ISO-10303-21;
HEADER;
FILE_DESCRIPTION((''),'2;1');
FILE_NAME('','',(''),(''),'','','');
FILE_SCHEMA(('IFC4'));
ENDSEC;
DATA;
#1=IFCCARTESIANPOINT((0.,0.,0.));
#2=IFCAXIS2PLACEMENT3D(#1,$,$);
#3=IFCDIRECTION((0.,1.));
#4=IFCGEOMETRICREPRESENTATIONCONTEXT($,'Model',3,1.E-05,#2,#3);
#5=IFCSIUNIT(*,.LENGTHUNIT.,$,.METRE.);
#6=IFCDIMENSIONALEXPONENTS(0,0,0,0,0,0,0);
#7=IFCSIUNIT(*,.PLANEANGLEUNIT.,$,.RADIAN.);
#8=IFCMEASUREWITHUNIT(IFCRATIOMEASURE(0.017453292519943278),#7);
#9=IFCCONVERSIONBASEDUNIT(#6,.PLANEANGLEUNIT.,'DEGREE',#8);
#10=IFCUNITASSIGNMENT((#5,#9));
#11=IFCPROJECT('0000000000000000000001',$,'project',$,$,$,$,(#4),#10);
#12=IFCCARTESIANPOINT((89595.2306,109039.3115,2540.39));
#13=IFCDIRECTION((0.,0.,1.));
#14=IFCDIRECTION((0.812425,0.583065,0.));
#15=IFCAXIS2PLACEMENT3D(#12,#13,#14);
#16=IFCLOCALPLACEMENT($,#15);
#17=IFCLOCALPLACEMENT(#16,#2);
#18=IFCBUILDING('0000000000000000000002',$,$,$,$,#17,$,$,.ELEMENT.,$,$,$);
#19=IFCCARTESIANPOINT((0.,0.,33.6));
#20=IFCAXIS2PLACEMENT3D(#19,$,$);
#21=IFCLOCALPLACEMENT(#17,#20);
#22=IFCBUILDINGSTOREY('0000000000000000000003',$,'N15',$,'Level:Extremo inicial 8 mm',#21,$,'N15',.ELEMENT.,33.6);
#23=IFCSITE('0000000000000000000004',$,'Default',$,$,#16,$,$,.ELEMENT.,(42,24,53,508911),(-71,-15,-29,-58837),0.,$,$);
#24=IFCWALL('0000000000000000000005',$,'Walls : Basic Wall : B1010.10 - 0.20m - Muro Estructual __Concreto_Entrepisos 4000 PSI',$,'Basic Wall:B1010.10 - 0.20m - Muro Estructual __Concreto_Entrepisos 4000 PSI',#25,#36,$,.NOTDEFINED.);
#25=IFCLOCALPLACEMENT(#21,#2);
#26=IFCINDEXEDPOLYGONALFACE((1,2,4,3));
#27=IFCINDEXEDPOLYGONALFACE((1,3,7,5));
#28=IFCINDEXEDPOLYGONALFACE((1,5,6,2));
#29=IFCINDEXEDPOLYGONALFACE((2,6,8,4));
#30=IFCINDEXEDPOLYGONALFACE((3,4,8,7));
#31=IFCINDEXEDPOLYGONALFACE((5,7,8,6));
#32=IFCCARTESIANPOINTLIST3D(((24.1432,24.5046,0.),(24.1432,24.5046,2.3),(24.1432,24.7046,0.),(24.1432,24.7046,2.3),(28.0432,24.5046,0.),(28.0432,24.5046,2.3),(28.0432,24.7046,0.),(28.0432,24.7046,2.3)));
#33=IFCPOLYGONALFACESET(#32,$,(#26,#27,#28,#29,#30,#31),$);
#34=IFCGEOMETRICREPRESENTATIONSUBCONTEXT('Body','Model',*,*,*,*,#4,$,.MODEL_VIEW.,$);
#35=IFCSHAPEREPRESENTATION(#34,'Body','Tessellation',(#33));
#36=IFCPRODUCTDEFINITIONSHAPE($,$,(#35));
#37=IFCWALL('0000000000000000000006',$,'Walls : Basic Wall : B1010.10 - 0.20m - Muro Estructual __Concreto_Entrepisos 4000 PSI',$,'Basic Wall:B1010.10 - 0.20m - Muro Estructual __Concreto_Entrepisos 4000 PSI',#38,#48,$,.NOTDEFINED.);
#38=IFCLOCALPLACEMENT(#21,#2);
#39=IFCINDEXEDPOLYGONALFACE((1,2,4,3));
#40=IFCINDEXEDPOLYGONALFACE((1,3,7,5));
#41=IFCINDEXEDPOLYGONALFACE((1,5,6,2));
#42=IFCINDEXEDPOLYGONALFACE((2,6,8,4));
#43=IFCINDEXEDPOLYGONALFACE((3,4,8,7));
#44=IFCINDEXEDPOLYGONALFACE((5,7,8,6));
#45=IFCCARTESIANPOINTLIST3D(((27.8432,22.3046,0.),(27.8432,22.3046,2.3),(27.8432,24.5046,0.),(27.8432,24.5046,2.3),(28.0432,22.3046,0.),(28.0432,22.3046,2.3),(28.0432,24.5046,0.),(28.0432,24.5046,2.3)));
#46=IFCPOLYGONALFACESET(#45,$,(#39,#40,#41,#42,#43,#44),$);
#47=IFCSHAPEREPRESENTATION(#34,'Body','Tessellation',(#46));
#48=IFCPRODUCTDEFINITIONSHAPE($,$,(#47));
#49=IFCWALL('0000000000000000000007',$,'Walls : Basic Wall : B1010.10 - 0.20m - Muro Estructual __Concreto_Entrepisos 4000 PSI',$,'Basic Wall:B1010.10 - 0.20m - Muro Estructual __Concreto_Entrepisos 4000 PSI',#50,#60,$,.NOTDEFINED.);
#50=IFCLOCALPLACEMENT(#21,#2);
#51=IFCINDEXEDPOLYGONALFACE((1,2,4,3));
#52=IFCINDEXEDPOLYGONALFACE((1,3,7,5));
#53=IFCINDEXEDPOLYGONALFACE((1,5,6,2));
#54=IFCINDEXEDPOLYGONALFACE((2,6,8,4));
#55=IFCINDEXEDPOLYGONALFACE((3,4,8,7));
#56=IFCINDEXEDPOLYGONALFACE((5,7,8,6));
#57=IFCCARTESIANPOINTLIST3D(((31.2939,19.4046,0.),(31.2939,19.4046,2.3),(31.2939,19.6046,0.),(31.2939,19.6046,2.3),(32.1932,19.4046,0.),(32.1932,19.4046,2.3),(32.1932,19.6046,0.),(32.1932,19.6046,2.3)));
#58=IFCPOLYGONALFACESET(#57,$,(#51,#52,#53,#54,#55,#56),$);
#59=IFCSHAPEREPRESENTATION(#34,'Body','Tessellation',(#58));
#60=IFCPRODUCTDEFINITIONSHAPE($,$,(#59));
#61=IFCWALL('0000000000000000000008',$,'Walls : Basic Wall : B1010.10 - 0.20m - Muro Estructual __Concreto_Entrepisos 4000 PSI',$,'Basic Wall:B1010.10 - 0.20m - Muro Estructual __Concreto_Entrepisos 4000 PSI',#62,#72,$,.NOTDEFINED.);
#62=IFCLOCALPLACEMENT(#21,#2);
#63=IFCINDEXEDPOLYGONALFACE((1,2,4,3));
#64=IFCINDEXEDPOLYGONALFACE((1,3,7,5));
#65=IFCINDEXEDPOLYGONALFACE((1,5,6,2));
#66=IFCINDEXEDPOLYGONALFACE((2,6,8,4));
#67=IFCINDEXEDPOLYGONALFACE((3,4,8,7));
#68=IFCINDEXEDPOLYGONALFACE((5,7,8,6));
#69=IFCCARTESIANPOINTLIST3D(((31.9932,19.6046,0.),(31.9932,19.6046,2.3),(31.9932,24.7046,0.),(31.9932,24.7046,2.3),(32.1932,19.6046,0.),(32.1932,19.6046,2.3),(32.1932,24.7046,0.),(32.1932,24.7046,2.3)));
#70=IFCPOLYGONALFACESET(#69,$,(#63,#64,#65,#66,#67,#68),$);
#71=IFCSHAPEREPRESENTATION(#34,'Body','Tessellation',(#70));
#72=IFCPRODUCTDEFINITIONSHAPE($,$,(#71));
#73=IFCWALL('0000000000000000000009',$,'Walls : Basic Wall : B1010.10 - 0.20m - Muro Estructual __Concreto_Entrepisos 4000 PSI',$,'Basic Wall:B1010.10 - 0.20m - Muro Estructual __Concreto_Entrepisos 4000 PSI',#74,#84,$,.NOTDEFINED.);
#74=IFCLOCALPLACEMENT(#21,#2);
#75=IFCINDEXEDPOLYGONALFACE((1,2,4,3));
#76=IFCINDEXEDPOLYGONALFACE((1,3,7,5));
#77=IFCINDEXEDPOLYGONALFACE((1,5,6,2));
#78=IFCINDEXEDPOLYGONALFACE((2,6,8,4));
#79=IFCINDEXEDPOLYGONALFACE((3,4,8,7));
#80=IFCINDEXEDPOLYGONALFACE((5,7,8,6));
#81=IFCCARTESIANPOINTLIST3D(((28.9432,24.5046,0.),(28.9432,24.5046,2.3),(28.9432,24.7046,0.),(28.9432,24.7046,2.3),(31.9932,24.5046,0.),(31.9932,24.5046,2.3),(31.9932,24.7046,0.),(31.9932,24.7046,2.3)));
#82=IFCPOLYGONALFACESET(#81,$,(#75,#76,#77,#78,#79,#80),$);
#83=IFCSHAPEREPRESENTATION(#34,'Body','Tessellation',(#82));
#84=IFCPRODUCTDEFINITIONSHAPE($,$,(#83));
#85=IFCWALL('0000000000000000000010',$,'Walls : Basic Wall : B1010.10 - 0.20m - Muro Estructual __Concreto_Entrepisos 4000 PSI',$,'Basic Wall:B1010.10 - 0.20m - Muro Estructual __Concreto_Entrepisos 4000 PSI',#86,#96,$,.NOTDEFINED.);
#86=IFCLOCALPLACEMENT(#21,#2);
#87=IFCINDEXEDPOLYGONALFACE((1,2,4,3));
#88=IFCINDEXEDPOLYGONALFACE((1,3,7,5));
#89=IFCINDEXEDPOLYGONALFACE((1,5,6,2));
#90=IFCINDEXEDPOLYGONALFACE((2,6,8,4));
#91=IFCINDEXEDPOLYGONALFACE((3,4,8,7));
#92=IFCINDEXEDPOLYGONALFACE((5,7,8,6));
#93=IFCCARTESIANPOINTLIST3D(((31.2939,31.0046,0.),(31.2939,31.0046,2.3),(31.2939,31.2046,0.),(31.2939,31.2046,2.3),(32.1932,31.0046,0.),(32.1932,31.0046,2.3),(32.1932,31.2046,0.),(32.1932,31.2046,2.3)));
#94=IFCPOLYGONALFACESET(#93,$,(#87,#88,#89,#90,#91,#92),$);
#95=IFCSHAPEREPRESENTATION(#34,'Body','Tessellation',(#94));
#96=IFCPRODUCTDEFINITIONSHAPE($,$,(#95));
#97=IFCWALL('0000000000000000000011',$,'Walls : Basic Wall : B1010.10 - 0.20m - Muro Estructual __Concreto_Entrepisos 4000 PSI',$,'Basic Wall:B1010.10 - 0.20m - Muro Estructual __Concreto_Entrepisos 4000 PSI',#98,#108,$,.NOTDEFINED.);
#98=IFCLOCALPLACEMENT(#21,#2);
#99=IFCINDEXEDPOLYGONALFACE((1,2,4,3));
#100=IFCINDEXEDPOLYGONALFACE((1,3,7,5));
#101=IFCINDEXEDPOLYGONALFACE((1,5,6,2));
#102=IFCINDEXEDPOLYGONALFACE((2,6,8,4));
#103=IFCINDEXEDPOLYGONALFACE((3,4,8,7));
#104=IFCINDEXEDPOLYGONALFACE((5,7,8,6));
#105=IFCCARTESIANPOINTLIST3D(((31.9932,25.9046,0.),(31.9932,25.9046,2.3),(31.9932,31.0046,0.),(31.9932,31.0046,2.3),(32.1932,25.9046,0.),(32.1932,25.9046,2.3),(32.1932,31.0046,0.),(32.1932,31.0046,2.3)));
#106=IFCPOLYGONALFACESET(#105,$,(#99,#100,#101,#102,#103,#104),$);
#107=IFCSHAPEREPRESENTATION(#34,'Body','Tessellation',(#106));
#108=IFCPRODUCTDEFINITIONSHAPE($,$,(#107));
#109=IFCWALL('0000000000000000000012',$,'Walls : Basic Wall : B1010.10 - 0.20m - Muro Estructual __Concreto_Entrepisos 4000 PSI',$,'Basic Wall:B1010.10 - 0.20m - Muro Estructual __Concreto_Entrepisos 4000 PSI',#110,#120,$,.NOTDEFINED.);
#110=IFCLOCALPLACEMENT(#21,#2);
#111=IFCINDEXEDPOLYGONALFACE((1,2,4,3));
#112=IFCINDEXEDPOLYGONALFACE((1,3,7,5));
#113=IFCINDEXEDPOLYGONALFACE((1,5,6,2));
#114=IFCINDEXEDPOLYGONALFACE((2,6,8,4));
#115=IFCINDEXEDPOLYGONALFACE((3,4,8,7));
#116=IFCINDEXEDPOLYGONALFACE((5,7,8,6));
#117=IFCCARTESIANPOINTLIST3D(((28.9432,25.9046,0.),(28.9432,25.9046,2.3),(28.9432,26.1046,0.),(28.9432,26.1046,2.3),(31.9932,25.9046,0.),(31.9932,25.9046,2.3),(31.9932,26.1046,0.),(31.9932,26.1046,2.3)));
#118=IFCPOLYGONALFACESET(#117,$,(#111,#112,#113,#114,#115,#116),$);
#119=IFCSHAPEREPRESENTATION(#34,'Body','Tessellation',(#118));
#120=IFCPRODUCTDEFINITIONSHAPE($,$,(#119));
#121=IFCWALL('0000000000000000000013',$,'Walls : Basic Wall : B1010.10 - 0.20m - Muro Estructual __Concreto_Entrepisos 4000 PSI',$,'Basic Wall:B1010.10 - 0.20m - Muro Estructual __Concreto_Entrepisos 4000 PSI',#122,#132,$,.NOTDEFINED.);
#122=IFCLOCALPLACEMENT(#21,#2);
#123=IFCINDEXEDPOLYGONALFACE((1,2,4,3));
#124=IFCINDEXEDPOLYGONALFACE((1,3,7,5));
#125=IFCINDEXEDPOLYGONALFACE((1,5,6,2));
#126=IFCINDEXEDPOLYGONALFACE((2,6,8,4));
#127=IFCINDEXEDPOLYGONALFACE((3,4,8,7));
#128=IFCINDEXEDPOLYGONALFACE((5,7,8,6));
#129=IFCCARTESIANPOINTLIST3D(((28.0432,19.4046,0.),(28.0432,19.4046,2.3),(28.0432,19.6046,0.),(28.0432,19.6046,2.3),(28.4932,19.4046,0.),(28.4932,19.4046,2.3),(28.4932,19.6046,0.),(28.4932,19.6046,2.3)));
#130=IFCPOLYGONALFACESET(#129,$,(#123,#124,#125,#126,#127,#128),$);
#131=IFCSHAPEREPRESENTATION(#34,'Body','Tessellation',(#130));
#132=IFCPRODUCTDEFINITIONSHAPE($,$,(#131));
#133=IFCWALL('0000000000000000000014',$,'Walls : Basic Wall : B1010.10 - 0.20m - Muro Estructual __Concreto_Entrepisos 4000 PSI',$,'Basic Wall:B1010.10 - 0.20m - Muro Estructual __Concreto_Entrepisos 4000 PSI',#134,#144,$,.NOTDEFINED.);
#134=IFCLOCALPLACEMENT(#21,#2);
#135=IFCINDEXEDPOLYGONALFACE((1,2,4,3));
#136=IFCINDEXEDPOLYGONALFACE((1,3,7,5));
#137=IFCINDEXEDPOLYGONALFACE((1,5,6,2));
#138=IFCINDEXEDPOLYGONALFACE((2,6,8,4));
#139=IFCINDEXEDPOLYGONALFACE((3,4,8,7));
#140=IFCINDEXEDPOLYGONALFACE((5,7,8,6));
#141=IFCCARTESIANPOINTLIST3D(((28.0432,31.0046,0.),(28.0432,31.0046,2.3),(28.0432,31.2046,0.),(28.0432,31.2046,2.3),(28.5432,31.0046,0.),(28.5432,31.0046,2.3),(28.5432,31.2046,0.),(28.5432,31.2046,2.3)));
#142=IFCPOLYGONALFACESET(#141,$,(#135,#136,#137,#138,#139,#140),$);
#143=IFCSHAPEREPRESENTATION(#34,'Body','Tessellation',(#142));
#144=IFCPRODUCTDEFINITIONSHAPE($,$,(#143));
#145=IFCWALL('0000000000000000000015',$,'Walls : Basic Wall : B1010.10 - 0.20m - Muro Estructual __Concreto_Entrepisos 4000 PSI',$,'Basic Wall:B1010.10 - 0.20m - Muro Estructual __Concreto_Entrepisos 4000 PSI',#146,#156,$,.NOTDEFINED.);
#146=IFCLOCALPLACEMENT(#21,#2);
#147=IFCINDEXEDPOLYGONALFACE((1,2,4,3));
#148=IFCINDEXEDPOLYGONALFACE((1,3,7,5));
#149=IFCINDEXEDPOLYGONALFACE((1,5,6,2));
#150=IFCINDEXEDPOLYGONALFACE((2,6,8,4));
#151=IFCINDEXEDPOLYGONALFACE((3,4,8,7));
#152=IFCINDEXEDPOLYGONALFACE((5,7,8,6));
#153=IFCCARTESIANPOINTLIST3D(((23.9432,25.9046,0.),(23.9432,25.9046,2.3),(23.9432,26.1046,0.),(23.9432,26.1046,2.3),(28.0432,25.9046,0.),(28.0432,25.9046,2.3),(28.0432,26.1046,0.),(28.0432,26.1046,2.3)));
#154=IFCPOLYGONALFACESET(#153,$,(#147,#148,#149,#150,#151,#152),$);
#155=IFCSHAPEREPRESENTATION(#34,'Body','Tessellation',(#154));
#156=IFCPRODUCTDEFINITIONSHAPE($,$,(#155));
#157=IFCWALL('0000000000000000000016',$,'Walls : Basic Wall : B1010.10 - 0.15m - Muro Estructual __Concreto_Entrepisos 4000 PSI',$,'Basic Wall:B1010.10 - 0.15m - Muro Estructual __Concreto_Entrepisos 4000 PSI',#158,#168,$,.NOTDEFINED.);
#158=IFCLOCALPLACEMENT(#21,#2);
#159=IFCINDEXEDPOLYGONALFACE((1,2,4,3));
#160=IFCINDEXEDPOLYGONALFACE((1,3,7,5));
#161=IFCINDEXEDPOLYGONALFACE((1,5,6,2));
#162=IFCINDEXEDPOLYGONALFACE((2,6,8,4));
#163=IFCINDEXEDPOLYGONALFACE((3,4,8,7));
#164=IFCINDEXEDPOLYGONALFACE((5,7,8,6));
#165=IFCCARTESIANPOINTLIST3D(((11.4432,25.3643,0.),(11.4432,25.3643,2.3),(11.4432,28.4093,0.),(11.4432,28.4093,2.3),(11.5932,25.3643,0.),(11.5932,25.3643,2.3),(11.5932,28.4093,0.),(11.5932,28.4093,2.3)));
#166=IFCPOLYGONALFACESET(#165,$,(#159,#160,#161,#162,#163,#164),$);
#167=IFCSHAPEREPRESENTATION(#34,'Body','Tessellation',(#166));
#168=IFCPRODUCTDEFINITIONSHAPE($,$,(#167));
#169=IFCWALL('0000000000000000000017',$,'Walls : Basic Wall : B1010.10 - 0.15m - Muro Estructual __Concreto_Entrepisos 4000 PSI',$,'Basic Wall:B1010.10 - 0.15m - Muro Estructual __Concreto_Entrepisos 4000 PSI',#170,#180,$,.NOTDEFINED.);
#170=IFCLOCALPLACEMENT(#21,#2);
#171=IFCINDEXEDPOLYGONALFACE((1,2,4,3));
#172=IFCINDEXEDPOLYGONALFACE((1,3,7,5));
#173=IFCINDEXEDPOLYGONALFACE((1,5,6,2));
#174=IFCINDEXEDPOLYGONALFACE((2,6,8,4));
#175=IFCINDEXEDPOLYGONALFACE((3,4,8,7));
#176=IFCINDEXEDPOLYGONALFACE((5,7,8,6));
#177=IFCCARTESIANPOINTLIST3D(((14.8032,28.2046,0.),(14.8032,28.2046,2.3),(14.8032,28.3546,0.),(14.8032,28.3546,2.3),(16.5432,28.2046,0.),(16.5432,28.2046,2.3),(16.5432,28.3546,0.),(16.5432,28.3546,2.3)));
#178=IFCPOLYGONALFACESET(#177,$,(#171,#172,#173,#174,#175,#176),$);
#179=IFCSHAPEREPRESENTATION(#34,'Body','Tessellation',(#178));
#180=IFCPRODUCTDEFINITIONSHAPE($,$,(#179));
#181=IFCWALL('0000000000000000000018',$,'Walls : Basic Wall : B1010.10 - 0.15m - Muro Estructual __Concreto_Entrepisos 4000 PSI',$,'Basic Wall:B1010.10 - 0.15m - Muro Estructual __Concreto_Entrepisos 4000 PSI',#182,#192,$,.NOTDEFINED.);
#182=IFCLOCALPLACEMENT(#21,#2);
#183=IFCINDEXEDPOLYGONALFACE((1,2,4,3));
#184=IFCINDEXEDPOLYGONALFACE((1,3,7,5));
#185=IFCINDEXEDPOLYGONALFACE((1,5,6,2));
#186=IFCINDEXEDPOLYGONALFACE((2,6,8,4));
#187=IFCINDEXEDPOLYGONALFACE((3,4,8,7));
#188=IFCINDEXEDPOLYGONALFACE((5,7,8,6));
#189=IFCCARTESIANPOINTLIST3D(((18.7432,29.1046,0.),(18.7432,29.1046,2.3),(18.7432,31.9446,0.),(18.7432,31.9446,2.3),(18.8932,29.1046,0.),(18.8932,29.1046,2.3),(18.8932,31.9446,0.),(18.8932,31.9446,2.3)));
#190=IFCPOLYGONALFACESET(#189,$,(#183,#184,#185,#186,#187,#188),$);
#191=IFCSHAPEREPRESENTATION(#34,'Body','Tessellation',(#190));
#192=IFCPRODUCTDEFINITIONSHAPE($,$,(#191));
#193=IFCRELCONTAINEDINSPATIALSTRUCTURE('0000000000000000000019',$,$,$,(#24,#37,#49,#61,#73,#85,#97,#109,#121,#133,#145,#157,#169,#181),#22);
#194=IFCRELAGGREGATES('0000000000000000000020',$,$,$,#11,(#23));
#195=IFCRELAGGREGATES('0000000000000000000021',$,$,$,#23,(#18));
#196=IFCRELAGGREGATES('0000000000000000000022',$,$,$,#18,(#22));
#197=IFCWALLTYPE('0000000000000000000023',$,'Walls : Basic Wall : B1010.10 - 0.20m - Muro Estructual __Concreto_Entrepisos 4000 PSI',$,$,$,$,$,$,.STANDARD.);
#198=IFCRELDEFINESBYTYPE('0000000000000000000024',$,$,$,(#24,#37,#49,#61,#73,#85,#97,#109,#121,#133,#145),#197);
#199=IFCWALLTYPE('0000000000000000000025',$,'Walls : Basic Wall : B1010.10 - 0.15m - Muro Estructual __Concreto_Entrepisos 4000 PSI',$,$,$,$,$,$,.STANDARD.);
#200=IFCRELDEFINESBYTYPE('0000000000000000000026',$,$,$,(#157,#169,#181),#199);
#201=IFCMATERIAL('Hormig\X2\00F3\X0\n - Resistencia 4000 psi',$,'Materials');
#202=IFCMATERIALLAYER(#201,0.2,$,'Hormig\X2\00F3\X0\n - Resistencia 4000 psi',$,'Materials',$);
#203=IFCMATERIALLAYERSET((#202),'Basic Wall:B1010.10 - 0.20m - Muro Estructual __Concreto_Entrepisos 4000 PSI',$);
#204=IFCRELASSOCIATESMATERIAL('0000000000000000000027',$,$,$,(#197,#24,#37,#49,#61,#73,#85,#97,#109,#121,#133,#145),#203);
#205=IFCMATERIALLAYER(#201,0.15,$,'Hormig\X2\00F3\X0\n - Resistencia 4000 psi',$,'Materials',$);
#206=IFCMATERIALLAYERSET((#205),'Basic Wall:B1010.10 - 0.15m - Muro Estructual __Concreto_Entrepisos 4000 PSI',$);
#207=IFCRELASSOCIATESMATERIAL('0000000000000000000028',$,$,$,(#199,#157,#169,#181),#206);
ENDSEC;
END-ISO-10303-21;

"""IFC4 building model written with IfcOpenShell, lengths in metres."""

from ifc_helpers import new_model, entity, si_unit, converted_unit, direction, frame, frame_2d, origin, place, context, subcontext, project, spatial, rectangle, extrude, material, layer, layer_set, layer_usage, type_object, element, save


model = new_model("IFC4")

# Units and contexts
model_context = context("Model", 3, precision=1e-05, world=origin(), true_north=direction((0.0, 1.0)))
body_context = subcontext(model_context, "Body", "Model", "MODEL_VIEW")
ifc_project = project(units=[si_unit("LENGTHUNIT", "METRE"), converted_unit("PLANEANGLEUNIT", "DEGREE", entity("IfcRatioMeasure", 0.017453292519943278), si_unit("PLANEANGLEUNIT", "RADIAN"), dimensions=[0, 0, 0, 0, 0, 0, 0])], contexts=[model_context])

# Site, building, storey
site_placement = place(None, frame((89595.2306, 109039.3115, 2540.39), z_axis=(0.0, 0.0, 1.0), x_axis=(0.812425, 0.583065, 0.0)))
site = spatial("IfcSite", under=ifc_project, at=site_placement, Name="Default", CompositionType="ELEMENT", RefLatitude=(42, 24, 53, 508911), RefLongitude=(-71, -15, -29, -58837), RefElevation=0.0)
building_placement = place(site_placement, origin())
building = spatial("IfcBuilding", under=site, at=building_placement, CompositionType="ELEMENT")
storey_placement = place(building_placement, frame((0.0, 0.0, 33.6)))
storey = spatial("IfcBuildingStorey", under=building, at=storey_placement, Name="N15", ObjectType="Level:Extremo inicial 8 mm", LongName="N15", CompositionType="ELEMENT", Elevation=33.6)

# Walls
ifc_material_1 = material(Name="Hormigón - Resistencia 4000 psi", Category="Materials")
ifc_layer_1 = layer(ifc_material_1, 0.2, Name="Hormigón - Resistencia 4000 psi", Category="Materials")
ifc_layer_set_1 = layer_set([ifc_layer_1], Name="Basic Wall:B1010.10 - 0.20m - Muro Estructual __Concreto_Entrepisos 4000 PSI")
wall_type_1 = type_object("IfcWallType", Name="Walls : Basic Wall : B1010.10 - 0.20m - Muro Estructual __Concreto_Entrepisos 4000 PSI", PredefinedType="STANDARD", material=ifc_layer_set_1)
ifc_layer_usage_1 = layer_usage(ifc_layer_set_1, "AXIS2", "NEGATIVE", 0.1)
wall_1_placement = place(storey_placement, frame((24.1432, 24.6046, 0.0)))
element("IfcWall", 1, at=wall_1_placement, inside=storey, type_object=wall_type_1, material=ifc_layer_usage_1, Name="Walls : Basic Wall : B1010.10 - 0.20m - Muro Estructual __Concreto_Entrepisos 4000 PSI", ObjectType="Basic Wall:B1010.10 - 0.20m - Muro Estructual __Concreto_Entrepisos 4000 PSI", PredefinedType="NOTDEFINED", context=body_context, shape_type="SweptSolid", body=[
    extrude(rectangle(XDim=3.9, YDim=0.2, at=frame_2d((1.95, 0.0), x_axis=(-1.0, 0.0))), origin(), (0.0, 0.0, 1.0), 2.3),
])
ifc_layer_usage_2 = layer_usage(ifc_layer_set_1, "AXIS2", "NEGATIVE", 0.1)
wall_2_placement = place(storey_placement, frame((27.9432, 24.5046, 0.0), z_axis=(0.0, 0.0, 1.0), x_axis=(0.0, -1.0, 0.0)))
element("IfcWall", 2, at=wall_2_placement, inside=storey, type_object=wall_type_1, material=ifc_layer_usage_2, Name="Walls : Basic Wall : B1010.10 - 0.20m - Muro Estructual __Concreto_Entrepisos 4000 PSI", ObjectType="Basic Wall:B1010.10 - 0.20m - Muro Estructual __Concreto_Entrepisos 4000 PSI", PredefinedType="NOTDEFINED", context=body_context, shape_type="SweptSolid", body=[
    extrude(rectangle(XDim=2.2, YDim=0.2, at=frame_2d((1.1, 0.0), x_axis=(-1.0, 0.0))), origin(), (0.0, 0.0, 1.0), 2.3),
])
ifc_layer_usage_3 = layer_usage(ifc_layer_set_1, "AXIS2", "NEGATIVE", 0.1)
wall_3_placement = place(storey_placement, frame((31.2939, 19.5046, 0.0)))
element("IfcWall", 3, at=wall_3_placement, inside=storey, type_object=wall_type_1, material=ifc_layer_usage_3, Name="Walls : Basic Wall : B1010.10 - 0.20m - Muro Estructual __Concreto_Entrepisos 4000 PSI", ObjectType="Basic Wall:B1010.10 - 0.20m - Muro Estructual __Concreto_Entrepisos 4000 PSI", PredefinedType="NOTDEFINED", context=body_context, shape_type="SweptSolid", body=[
    extrude(rectangle(XDim=0.8993, YDim=0.2, at=frame_2d((0.4497, 0.0), x_axis=(-1.0, 0.0))), origin(), (0.0, 0.0, 1.0), 2.3),
])
ifc_layer_usage_4 = layer_usage(ifc_layer_set_1, "AXIS2", "NEGATIVE", 0.1)
wall_4_placement = place(storey_placement, frame((32.0932, 19.6046, 0.0), z_axis=(0.0, 0.0, 1.0), x_axis=(0.0, 1.0, 0.0)))
element("IfcWall", 4, at=wall_4_placement, inside=storey, type_object=wall_type_1, material=ifc_layer_usage_4, Name="Walls : Basic Wall : B1010.10 - 0.20m - Muro Estructual __Concreto_Entrepisos 4000 PSI", ObjectType="Basic Wall:B1010.10 - 0.20m - Muro Estructual __Concreto_Entrepisos 4000 PSI", PredefinedType="NOTDEFINED", context=body_context, shape_type="SweptSolid", body=[
    extrude(rectangle(XDim=5.1, YDim=0.2, at=frame_2d((2.55, 0.0), x_axis=(-1.0, 0.0))), origin(), (0.0, 0.0, 1.0), 2.3),
])
ifc_layer_usage_5 = layer_usage(ifc_layer_set_1, "AXIS2", "NEGATIVE", 0.1)
wall_5_placement = place(storey_placement, frame((31.9932, 24.6046, 0.0), z_axis=(0.0, 0.0, 1.0), x_axis=(-1.0, 0.0, 0.0)))
element("IfcWall", 5, at=wall_5_placement, inside=storey, type_object=wall_type_1, material=ifc_layer_usage_5, Name="Walls : Basic Wall : B1010.10 - 0.20m - Muro Estructual __Concreto_Entrepisos 4000 PSI", ObjectType="Basic Wall:B1010.10 - 0.20m - Muro Estructual __Concreto_Entrepisos 4000 PSI", PredefinedType="NOTDEFINED", context=body_context, shape_type="SweptSolid", body=[
    extrude(rectangle(XDim=3.05, YDim=0.2, at=frame_2d((1.525, 0.0), x_axis=(-1.0, 0.0))), origin(), (0.0, 0.0, 1.0), 2.3),
])
ifc_layer_usage_6 = layer_usage(ifc_layer_set_1, "AXIS2", "POSITIVE", -0.1)
wall_6_placement = place(storey_placement, frame((31.2939, 31.1046, 0.0)))
element("IfcWall", 6, at=wall_6_placement, inside=storey, type_object=wall_type_1, material=ifc_layer_usage_6, Name="Walls : Basic Wall : B1010.10 - 0.20m - Muro Estructual __Concreto_Entrepisos 4000 PSI", ObjectType="Basic Wall:B1010.10 - 0.20m - Muro Estructual __Concreto_Entrepisos 4000 PSI", PredefinedType="NOTDEFINED", context=body_context, shape_type="SweptSolid", body=[
    extrude(rectangle(XDim=0.8993, YDim=0.2, at=frame_2d((0.4497, 0.0), x_axis=(-1.0, 0.0))), origin(), (0.0, 0.0, 1.0), 2.3),
])
ifc_layer_usage_7 = layer_usage(ifc_layer_set_1, "AXIS2", "POSITIVE", -0.1)
wall_7_placement = place(storey_placement, frame((32.0932, 31.0046, 0.0), z_axis=(0.0, 0.0, 1.0), x_axis=(0.0, -1.0, 0.0)))
element("IfcWall", 7, at=wall_7_placement, inside=storey, type_object=wall_type_1, material=ifc_layer_usage_7, Name="Walls : Basic Wall : B1010.10 - 0.20m - Muro Estructual __Concreto_Entrepisos 4000 PSI", ObjectType="Basic Wall:B1010.10 - 0.20m - Muro Estructual __Concreto_Entrepisos 4000 PSI", PredefinedType="NOTDEFINED", context=body_context, shape_type="SweptSolid", body=[
    extrude(rectangle(XDim=5.1, YDim=0.2, at=frame_2d((2.55, 0.0), x_axis=(-1.0, 0.0))), origin(), (0.0, 0.0, 1.0), 2.3),
])
ifc_layer_usage_8 = layer_usage(ifc_layer_set_1, "AXIS2", "POSITIVE", -0.1)
wall_8_placement = place(storey_placement, frame((31.9932, 26.0046, 0.0), z_axis=(0.0, 0.0, 1.0), x_axis=(-1.0, 0.0, 0.0)))
element("IfcWall", 8, at=wall_8_placement, inside=storey, type_object=wall_type_1, material=ifc_layer_usage_8, Name="Walls : Basic Wall : B1010.10 - 0.20m - Muro Estructual __Concreto_Entrepisos 4000 PSI", ObjectType="Basic Wall:B1010.10 - 0.20m - Muro Estructual __Concreto_Entrepisos 4000 PSI", PredefinedType="NOTDEFINED", context=body_context, shape_type="SweptSolid", body=[
    extrude(rectangle(XDim=3.05, YDim=0.2, at=frame_2d((1.525, 0.0), x_axis=(-1.0, 0.0))), origin(), (0.0, 0.0, 1.0), 2.3),
])
ifc_layer_usage_9 = layer_usage(ifc_layer_set_1, "AXIS2", "NEGATIVE", 0.1)
wall_9_placement = place(storey_placement, frame((28.4932, 19.5046, 0.0), z_axis=(0.0, 0.0, 1.0), x_axis=(-1.0, 0.0, 0.0)))
element("IfcWall", 9, at=wall_9_placement, inside=storey, type_object=wall_type_1, material=ifc_layer_usage_9, Name="Walls : Basic Wall : B1010.10 - 0.20m - Muro Estructual __Concreto_Entrepisos 4000 PSI", ObjectType="Basic Wall:B1010.10 - 0.20m - Muro Estructual __Concreto_Entrepisos 4000 PSI", PredefinedType="NOTDEFINED", context=body_context, shape_type="SweptSolid", body=[
    extrude(rectangle(XDim=0.45, YDim=0.2, at=frame_2d((0.225, 0.0), x_axis=(-1.0, 0.0))), origin(), (0.0, 0.0, 1.0), 2.3),
])
ifc_layer_usage_10 = layer_usage(ifc_layer_set_1, "AXIS2", "NEGATIVE", 0.1)
wall_10_placement = place(storey_placement, frame((28.5432, 31.1046, 0.0), z_axis=(0.0, 0.0, 1.0), x_axis=(-1.0, 0.0, 0.0)))
element("IfcWall", 10, at=wall_10_placement, inside=storey, type_object=wall_type_1, material=ifc_layer_usage_10, Name="Walls : Basic Wall : B1010.10 - 0.20m - Muro Estructual __Concreto_Entrepisos 4000 PSI", ObjectType="Basic Wall:B1010.10 - 0.20m - Muro Estructual __Concreto_Entrepisos 4000 PSI", PredefinedType="NOTDEFINED", context=body_context, shape_type="SweptSolid", body=[
    extrude(rectangle(XDim=0.5, YDim=0.2, at=frame_2d((0.25, 0.0), x_axis=(-1.0, 0.0))), origin(), (0.0, 0.0, 1.0), 2.3),
])
ifc_layer_usage_11 = layer_usage(ifc_layer_set_1, "AXIS2", "NEGATIVE", 0.1)
wall_11_placement = place(storey_placement, frame((23.9432, 26.0046, 0.0)))
element("IfcWall", 11, at=wall_11_placement, inside=storey, type_object=wall_type_1, material=ifc_layer_usage_11, Name="Walls : Basic Wall : B1010.10 - 0.20m - Muro Estructual __Concreto_Entrepisos 4000 PSI", ObjectType="Basic Wall:B1010.10 - 0.20m - Muro Estructual __Concreto_Entrepisos 4000 PSI", PredefinedType="NOTDEFINED", context=body_context, shape_type="SweptSolid", body=[
    extrude(rectangle(XDim=4.1, YDim=0.2, at=frame_2d((2.05, 0.0), x_axis=(-1.0, 0.0))), origin(), (0.0, 0.0, 1.0), 2.3),
])
ifc_layer_2 = layer(ifc_material_1, 0.15, Name="Hormigón - Resistencia 4000 psi", Category="Materials")
ifc_layer_set_2 = layer_set([ifc_layer_2], Name="Basic Wall:B1010.10 - 0.15m - Muro Estructual __Concreto_Entrepisos 4000 PSI")
ifc_layer_usage_12 = layer_usage(ifc_layer_set_2, "AXIS2", "NEGATIVE", 0.075)
wall_type_2 = type_object("IfcWallType", Name="Walls : Basic Wall : B1010.10 - 0.15m - Muro Estructual __Concreto_Entrepisos 4000 PSI", PredefinedType="STANDARD", material=ifc_layer_set_2)
wall_12_placement = place(storey_placement, frame((11.5182, 25.3643, 0.0), z_axis=(0.0, 0.0, 1.0), x_axis=(0.0, 1.0, 0.0)))
element("IfcWall", 12, at=wall_12_placement, inside=storey, type_object=wall_type_2, material=ifc_layer_usage_12, Name="Walls : Basic Wall : B1010.10 - 0.15m - Muro Estructual __Concreto_Entrepisos 4000 PSI", ObjectType="Basic Wall:B1010.10 - 0.15m - Muro Estructual __Concreto_Entrepisos 4000 PSI", PredefinedType="NOTDEFINED", context=body_context, shape_type="SweptSolid", body=[
    extrude(rectangle(XDim=3.045, YDim=0.15, at=frame_2d((1.5225, 0.0), x_axis=(-1.0, 0.0))), origin(), (0.0, 0.0, 1.0), 2.3),
])
ifc_layer_usage_13 = layer_usage(ifc_layer_set_2, "AXIS2", "NEGATIVE", 0.075)
wall_13_placement = place(storey_placement, frame((16.5432, 28.2796, 0.0), z_axis=(0.0, 0.0, 1.0), x_axis=(-1.0, 0.0, 0.0)))
element("IfcWall", 13, at=wall_13_placement, inside=storey, type_object=wall_type_2, material=ifc_layer_usage_13, Name="Walls : Basic Wall : B1010.10 - 0.15m - Muro Estructual __Concreto_Entrepisos 4000 PSI", ObjectType="Basic Wall:B1010.10 - 0.15m - Muro Estructual __Concreto_Entrepisos 4000 PSI", PredefinedType="NOTDEFINED", context=body_context, shape_type="SweptSolid", body=[
    extrude(rectangle(XDim=1.74, YDim=0.15, at=frame_2d((0.87, 0.0), x_axis=(-1.0, 0.0))), origin(), (0.0, 0.0, 1.0), 2.3),
])
ifc_layer_usage_14 = layer_usage(ifc_layer_set_2, "AXIS2", "NEGATIVE", 0.075)
wall_14_placement = place(storey_placement, frame((18.8182, 31.9446, 0.0), z_axis=(0.0, 0.0, 1.0), x_axis=(0.0, -1.0, 0.0)))
element("IfcWall", 14, at=wall_14_placement, inside=storey, type_object=wall_type_2, material=ifc_layer_usage_14, Name="Walls : Basic Wall : B1010.10 - 0.15m - Muro Estructual __Concreto_Entrepisos 4000 PSI", ObjectType="Basic Wall:B1010.10 - 0.15m - Muro Estructual __Concreto_Entrepisos 4000 PSI", PredefinedType="NOTDEFINED", context=body_context, shape_type="SweptSolid", body=[
    extrude(rectangle(XDim=2.84, YDim=0.15, at=frame_2d((1.42, 0.0), x_axis=(-1.0, 0.0))), origin(), (0.0, 0.0, 1.0), 2.3),
])

save(model, "model.ifc")
